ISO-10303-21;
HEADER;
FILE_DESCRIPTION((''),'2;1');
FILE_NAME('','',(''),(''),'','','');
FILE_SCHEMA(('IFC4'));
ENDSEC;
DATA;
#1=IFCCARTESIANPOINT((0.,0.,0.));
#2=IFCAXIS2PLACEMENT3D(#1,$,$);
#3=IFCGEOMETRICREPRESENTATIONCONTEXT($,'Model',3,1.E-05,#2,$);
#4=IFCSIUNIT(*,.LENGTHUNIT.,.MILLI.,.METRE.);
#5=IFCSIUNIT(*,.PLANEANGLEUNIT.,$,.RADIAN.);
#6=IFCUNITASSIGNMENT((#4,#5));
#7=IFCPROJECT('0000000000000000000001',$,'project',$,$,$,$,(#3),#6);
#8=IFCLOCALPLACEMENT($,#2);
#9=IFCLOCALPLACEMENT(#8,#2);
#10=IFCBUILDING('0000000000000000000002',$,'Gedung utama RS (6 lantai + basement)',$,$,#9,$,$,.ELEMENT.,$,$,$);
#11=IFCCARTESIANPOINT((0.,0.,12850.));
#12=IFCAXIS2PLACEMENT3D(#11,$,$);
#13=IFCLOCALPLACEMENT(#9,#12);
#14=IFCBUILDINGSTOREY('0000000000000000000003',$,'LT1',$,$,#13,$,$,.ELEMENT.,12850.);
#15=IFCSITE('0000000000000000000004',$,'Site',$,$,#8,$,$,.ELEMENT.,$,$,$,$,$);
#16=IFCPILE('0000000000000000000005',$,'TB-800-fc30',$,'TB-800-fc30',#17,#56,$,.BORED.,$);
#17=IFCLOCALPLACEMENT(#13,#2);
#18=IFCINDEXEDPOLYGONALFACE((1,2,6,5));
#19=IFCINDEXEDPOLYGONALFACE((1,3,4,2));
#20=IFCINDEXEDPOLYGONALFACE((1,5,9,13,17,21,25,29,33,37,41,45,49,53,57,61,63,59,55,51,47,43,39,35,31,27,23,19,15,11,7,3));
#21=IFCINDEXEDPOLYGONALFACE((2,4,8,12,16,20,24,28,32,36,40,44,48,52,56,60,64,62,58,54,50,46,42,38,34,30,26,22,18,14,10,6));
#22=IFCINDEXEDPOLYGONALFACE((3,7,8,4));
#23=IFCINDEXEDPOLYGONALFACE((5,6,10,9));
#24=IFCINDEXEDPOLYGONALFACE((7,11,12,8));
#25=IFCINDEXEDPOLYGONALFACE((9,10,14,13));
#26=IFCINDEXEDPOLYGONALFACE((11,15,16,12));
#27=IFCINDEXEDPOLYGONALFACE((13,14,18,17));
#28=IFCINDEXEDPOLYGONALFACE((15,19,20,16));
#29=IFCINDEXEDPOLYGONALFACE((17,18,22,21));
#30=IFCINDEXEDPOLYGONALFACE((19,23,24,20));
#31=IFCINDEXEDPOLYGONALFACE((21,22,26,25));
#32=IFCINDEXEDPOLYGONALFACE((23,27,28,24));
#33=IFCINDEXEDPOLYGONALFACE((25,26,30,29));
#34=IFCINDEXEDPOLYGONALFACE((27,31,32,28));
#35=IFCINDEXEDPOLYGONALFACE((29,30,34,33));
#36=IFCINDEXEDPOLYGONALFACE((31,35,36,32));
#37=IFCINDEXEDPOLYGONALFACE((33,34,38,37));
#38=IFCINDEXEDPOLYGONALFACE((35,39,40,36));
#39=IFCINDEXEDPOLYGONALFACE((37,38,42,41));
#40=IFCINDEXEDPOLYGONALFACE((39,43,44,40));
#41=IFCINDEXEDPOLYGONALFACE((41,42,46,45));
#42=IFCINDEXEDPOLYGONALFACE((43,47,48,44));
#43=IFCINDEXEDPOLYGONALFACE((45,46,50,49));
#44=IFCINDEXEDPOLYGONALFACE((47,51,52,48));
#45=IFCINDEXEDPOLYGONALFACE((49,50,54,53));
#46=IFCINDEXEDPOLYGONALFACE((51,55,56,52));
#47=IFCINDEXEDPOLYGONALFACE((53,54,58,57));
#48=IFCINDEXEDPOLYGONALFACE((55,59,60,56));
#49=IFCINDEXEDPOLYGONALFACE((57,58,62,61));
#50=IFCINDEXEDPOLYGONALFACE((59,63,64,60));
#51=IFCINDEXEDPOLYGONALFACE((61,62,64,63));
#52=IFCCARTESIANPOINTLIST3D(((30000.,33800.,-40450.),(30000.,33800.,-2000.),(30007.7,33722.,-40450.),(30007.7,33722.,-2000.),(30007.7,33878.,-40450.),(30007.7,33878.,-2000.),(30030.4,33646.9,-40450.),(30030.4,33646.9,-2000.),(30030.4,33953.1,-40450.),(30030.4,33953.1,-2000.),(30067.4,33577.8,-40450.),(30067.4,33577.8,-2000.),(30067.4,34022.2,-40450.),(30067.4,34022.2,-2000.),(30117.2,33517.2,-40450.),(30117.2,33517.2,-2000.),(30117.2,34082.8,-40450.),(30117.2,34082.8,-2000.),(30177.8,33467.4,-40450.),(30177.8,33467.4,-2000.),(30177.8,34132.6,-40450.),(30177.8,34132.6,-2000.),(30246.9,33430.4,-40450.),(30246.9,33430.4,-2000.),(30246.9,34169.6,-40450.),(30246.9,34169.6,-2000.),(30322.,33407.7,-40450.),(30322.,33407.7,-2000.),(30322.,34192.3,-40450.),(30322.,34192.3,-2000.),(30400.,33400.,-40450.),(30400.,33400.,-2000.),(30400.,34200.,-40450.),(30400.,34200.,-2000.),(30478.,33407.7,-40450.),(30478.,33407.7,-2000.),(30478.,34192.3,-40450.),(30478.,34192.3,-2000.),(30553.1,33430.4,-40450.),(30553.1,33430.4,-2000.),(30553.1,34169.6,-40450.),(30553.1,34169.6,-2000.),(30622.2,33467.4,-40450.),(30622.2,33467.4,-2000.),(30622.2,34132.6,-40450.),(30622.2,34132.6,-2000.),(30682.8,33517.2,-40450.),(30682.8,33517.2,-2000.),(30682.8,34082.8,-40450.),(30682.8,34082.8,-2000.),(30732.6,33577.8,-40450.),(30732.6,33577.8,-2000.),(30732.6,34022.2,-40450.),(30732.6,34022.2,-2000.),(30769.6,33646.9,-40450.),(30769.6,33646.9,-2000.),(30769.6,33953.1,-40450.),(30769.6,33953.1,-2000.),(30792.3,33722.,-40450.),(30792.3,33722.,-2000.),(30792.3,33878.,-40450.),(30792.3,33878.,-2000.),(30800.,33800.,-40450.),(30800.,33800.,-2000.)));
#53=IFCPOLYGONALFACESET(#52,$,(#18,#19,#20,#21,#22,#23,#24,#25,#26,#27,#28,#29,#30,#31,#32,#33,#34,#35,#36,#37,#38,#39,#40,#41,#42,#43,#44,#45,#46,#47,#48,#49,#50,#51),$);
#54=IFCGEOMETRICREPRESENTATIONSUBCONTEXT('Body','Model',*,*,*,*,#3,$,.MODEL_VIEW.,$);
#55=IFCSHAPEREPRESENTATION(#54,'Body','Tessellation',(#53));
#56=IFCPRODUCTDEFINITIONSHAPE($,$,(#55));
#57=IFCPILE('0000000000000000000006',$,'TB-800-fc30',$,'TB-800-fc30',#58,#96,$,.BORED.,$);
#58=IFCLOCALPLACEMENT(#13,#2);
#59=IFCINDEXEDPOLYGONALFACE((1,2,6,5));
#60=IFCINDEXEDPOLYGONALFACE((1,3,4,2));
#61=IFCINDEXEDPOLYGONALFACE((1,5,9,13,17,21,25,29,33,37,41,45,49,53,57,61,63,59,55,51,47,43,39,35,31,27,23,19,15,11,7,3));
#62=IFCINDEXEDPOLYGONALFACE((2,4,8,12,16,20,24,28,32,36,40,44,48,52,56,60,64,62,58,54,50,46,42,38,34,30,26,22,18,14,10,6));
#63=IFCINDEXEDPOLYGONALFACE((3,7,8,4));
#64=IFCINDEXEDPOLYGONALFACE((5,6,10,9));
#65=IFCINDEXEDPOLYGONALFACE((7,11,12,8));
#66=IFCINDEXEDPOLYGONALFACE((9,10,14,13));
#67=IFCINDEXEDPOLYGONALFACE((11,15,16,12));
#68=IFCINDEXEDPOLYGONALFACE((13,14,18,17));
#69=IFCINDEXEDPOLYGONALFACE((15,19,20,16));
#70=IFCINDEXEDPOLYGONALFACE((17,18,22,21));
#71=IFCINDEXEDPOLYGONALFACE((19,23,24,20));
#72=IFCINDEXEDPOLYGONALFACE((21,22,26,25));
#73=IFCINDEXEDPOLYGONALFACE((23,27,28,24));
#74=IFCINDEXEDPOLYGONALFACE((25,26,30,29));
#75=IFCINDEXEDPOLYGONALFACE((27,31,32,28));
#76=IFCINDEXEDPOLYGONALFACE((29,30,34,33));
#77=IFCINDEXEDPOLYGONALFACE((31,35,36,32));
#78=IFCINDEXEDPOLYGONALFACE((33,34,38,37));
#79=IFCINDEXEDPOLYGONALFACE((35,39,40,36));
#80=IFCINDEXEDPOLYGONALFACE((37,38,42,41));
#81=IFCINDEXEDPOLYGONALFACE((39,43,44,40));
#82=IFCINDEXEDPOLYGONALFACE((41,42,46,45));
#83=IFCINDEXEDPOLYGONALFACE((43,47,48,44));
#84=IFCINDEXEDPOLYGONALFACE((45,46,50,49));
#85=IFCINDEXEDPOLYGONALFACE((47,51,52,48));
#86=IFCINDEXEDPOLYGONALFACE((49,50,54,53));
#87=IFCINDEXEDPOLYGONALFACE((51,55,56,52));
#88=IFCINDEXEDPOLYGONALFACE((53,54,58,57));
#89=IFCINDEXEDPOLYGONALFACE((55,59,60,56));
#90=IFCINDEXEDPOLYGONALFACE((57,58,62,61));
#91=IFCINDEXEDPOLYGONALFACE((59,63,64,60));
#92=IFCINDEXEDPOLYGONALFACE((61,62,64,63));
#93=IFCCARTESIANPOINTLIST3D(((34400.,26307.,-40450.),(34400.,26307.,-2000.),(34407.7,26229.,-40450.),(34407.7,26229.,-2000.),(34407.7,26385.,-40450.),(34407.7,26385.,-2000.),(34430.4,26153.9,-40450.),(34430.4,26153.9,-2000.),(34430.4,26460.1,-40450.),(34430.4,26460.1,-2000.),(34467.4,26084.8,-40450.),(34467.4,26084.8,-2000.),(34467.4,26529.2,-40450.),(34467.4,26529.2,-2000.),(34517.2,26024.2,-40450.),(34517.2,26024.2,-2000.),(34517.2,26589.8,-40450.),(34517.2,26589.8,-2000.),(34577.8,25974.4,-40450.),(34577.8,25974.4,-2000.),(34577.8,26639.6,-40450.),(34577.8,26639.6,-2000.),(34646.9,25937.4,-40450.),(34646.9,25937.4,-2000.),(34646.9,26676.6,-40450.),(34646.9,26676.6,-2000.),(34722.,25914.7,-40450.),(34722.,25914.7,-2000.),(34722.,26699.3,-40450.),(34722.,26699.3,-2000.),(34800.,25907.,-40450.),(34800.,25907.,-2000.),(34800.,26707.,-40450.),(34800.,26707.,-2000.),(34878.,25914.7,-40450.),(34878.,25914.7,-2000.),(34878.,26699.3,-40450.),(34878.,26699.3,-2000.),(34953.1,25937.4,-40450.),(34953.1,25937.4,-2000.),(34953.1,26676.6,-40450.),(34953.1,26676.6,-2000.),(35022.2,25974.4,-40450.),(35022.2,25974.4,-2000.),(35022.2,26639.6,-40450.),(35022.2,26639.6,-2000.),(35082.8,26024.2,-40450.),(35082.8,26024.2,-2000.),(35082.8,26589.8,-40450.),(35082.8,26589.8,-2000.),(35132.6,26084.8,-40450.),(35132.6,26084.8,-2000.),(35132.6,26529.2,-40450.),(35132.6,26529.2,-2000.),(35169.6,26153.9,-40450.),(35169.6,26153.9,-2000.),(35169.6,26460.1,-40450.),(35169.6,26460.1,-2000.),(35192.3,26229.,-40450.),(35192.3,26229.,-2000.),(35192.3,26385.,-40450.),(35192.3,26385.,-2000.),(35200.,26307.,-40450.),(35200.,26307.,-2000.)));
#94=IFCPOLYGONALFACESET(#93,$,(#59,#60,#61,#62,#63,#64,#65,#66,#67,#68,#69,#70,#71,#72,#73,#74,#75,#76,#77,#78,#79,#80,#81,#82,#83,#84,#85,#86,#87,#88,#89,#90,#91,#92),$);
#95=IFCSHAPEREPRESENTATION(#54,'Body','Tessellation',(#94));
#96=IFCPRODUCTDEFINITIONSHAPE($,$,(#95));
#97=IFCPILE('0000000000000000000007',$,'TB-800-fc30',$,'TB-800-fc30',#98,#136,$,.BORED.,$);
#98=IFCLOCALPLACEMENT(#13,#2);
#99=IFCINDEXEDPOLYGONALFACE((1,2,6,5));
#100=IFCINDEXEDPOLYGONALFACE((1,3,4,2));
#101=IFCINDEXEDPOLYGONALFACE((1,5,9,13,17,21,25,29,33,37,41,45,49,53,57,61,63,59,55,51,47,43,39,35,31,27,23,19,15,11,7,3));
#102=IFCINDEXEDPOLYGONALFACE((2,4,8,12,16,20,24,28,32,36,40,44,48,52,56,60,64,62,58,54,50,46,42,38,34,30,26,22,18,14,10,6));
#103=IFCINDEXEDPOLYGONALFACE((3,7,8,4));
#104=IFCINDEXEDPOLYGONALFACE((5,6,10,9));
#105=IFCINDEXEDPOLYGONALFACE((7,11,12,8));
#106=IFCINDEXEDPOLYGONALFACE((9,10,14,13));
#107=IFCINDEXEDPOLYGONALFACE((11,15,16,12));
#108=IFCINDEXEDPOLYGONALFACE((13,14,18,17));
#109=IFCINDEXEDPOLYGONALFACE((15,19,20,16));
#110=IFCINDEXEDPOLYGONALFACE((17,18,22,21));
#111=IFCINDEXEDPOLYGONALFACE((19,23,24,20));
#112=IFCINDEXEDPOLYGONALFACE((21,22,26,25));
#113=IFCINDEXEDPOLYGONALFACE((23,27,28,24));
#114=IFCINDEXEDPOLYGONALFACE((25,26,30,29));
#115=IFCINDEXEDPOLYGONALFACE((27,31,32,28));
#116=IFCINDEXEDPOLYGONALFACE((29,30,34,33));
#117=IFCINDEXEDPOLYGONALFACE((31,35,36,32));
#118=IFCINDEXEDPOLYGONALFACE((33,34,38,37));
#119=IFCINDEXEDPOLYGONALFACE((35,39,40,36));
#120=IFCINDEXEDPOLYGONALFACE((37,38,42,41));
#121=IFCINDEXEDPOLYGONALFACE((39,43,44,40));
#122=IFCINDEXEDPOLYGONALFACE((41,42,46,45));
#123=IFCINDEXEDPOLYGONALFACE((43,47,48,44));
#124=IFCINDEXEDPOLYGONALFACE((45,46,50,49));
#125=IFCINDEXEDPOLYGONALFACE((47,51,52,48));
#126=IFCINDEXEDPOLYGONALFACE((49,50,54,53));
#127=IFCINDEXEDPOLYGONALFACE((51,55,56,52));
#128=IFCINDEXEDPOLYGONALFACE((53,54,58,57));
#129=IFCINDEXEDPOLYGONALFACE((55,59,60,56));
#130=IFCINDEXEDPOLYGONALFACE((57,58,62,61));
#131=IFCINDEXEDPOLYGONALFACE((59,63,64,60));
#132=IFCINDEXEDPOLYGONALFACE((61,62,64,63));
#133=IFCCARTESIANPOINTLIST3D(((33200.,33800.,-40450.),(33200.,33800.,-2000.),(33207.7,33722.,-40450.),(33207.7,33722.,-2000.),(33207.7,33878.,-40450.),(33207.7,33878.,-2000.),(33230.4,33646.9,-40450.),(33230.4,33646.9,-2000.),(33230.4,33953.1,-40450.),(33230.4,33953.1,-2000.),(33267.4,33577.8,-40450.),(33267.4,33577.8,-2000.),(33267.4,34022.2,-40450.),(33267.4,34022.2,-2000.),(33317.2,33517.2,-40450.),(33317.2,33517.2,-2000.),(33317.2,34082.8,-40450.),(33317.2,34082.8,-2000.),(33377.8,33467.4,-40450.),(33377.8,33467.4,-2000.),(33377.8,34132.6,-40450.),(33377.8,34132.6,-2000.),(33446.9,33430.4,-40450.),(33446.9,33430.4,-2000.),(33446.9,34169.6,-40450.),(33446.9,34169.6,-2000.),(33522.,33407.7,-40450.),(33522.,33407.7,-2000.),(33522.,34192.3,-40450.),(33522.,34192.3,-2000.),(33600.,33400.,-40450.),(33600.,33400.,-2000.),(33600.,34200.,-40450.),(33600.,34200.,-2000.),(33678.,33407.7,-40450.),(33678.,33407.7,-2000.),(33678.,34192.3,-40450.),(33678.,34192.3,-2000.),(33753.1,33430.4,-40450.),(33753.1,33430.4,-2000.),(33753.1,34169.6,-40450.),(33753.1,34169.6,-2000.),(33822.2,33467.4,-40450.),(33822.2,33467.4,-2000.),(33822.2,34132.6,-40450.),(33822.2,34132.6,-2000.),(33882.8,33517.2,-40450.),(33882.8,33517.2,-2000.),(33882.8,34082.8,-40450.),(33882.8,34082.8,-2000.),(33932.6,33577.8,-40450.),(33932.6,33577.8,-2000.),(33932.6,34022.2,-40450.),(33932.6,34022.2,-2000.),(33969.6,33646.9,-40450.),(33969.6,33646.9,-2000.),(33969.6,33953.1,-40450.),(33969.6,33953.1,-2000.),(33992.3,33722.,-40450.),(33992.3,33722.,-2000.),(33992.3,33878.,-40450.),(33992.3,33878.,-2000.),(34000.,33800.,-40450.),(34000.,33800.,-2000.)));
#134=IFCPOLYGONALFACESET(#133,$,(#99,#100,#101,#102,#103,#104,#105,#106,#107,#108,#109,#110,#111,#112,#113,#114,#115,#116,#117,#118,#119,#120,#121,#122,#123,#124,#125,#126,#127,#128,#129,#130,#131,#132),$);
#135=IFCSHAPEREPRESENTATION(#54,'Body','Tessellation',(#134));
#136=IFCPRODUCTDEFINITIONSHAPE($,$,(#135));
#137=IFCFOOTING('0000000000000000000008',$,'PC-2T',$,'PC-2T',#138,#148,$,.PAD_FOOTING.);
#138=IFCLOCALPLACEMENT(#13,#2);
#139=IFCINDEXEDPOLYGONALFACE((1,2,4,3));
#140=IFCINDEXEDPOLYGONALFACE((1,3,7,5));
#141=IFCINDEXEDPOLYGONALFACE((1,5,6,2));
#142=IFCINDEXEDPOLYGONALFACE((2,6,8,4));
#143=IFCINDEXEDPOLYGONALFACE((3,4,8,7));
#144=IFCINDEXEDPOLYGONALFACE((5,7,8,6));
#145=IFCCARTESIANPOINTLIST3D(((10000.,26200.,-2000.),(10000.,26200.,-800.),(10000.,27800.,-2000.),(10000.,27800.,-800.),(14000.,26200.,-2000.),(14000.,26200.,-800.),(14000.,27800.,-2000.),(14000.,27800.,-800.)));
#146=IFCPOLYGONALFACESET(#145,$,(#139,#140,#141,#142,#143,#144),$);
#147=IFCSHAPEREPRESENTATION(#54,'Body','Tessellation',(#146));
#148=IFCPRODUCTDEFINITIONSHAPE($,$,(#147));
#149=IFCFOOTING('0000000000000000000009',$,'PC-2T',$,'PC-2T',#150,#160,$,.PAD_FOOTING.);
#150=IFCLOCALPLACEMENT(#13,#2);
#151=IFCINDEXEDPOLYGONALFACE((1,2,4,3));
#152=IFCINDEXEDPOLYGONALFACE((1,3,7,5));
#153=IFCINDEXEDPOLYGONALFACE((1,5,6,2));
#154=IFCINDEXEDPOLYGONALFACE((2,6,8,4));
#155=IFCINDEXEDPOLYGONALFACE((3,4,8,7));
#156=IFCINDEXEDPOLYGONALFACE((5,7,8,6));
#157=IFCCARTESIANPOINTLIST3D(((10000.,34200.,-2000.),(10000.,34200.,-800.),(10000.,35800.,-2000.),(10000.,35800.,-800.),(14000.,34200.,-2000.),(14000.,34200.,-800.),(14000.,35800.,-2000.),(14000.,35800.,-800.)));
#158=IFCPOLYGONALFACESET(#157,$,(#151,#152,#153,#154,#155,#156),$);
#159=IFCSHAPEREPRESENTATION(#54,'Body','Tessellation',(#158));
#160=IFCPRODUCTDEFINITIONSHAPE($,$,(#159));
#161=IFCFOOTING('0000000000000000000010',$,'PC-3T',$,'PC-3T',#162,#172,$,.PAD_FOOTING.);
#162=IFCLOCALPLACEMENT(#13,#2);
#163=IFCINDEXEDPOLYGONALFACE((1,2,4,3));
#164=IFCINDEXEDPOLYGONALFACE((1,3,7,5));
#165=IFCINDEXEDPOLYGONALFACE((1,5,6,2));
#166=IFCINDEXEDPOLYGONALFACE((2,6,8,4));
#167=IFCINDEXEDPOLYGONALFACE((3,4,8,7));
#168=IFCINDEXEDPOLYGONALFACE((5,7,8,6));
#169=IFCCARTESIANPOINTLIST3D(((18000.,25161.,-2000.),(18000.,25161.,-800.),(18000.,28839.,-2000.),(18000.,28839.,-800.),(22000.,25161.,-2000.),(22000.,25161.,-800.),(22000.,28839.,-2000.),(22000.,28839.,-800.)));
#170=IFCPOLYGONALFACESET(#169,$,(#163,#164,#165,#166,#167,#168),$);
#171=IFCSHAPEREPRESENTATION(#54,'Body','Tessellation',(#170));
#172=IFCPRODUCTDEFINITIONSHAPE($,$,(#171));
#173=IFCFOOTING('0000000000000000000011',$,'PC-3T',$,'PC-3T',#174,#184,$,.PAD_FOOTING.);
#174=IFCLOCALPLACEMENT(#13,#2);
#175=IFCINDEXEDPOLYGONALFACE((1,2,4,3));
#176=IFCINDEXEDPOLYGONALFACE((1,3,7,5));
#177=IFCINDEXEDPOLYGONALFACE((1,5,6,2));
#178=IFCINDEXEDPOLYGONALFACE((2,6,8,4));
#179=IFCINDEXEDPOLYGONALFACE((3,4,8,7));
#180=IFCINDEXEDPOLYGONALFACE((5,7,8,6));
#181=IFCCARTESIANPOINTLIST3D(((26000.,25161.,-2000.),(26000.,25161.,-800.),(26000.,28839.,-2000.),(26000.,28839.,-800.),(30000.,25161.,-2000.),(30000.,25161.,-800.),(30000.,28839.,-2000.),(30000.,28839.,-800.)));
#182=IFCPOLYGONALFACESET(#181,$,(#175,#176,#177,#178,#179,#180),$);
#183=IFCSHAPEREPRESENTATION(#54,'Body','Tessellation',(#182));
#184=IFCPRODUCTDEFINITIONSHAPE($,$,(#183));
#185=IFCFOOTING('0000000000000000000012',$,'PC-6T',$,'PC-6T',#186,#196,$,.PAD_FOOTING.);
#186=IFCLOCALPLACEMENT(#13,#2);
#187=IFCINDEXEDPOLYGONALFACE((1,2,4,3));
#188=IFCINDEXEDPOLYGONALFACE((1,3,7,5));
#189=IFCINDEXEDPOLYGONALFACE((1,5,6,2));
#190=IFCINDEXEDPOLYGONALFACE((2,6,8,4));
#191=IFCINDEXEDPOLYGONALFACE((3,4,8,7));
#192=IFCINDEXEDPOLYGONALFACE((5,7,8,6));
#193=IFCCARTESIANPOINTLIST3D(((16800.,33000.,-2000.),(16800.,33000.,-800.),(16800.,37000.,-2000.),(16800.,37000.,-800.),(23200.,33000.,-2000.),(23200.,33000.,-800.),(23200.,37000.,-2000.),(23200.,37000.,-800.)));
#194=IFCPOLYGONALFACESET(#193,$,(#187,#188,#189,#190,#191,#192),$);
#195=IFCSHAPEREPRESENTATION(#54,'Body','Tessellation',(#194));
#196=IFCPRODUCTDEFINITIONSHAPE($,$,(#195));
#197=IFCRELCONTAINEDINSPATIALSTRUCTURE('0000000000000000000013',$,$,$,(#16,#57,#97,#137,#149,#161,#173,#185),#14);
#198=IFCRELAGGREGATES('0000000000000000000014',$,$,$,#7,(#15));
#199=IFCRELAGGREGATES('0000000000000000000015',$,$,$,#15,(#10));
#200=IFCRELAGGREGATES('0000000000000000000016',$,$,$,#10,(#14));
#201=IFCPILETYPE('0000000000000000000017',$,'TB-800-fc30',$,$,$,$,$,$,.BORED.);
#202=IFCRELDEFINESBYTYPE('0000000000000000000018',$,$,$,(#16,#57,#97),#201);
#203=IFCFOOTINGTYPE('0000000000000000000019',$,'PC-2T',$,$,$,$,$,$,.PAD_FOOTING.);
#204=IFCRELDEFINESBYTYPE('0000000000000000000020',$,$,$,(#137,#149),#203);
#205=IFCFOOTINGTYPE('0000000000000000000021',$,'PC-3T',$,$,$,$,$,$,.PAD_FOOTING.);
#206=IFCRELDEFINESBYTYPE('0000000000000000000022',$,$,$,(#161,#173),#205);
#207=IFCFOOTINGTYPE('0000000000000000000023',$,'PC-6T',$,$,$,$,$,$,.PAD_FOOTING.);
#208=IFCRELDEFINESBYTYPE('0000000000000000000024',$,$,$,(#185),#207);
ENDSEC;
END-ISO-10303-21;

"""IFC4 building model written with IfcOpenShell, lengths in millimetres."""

from ifc_helpers import new_model, si_unit, frame, origin, origin_2d, place, context, subcontext, project, spatial, rectangle, circle, extrude, material_profile, profile_set, profile_usage, type_object, element, save


model = new_model("IFC4")

# Units and contexts
model_context = context("Model", 3, precision=1e-05, world=origin())
body_context = subcontext(model_context, "Body", "Model", "MODEL_VIEW")
ifc_project = project(units=[si_unit("LENGTHUNIT", "METRE", prefix="MILLI"), si_unit("PLANEANGLEUNIT", "RADIAN")], contexts=[model_context])

# Site, building, storey
site_placement = place(None, origin())
site = spatial("IfcSite", under=ifc_project, at=site_placement, Name="Site", CompositionType="ELEMENT")
building_placement = place(site_placement, origin())
building = spatial("IfcBuilding", under=site, at=building_placement, Name="Gedung utama RS (6 lantai + basement)", CompositionType="ELEMENT")
storey_placement = place(building_placement, frame((0.0, 0.0, 12850.0)))
storey = spatial("IfcBuildingStorey", under=building, at=storey_placement, Name="LT1", CompositionType="ELEMENT", Elevation=12850.0)

# Piles
ifc_material_profile_1 = material_profile(None, circle(Radius=400.0, at=origin_2d()), Name="TB-800-fc30")
ifc_profile_set_1 = profile_set([ifc_material_profile_1], Name="TB-800-fc30")
ifc_profile_usage_1 = profile_usage(ifc_profile_set_1, cardinal=5)
pile_type = type_object("IfcPileType", Name="TB-800-fc30", PredefinedType="BORED", material=ifc_profile_set_1)
for number, where, z_axis, x_axis, name in (
    (1, (30400.0, 33800.0, -40450.0), (0.0, 0.0, 1.0), (1.0, 0.0, 0.0), "TB-800-fc30"),
    (2, (34800.0, 26307.0, -40450.0), (0.0, 0.0, 1.0), (1.0, 0.0, 0.0), "TB-800-fc30"),
    (3, (33600.0, 33800.0, -40450.0), (0.0, 0.0, 1.0), (1.0, 0.0, 0.0), "TB-800-fc30"),
):
    element("IfcPile", number, at=place(storey_placement, frame(where, z_axis=z_axis, x_axis=x_axis)), inside=storey, type_object=pile_type, material=ifc_profile_usage_1, Name=name, ObjectType="TB-800-fc30", PredefinedType="BORED", context=body_context, shape_type="SweptSolid", body=[
        extrude(circle(Radius=400.0, at=origin_2d()), origin(), (0.0, 0.0, 1.0), 38450.0),
    ])

# Footings
ifc_material_profile_2 = material_profile(None, rectangle(XDim=4000.0, YDim=1600.0, at=origin_2d()), Name="PC-2T")
ifc_profile_set_2 = profile_set([ifc_material_profile_2], Name="PC-2T")
ifc_profile_usage_2 = profile_usage(ifc_profile_set_2, cardinal=5)
footing_type_1 = type_object("IfcFootingType", Name="PC-2T", PredefinedType="PAD_FOOTING", material=ifc_profile_set_2)
for number, where, z_axis, x_axis, name in (
    (4, (12000.0, 27000.0, -2000.0), (0.0, 0.0, 1.0), (1.0, 0.0, 0.0), "PC-2T"),
    (5, (12000.0, 35000.0, -2000.0), (0.0, 0.0, 1.0), (1.0, 0.0, 0.0), "PC-2T"),
):
    element("IfcFooting", number, at=place(storey_placement, frame(where, z_axis=z_axis, x_axis=x_axis)), inside=storey, type_object=footing_type_1, material=ifc_profile_usage_2, Name=name, ObjectType="PC-2T", PredefinedType="PAD_FOOTING", context=body_context, shape_type="SweptSolid", body=[
        extrude(rectangle(XDim=4000.0, YDim=1600.0, at=origin_2d()), origin(), (0.0, 0.0, 1.0), 1200.0),
    ])
ifc_material_profile_3 = material_profile(None, rectangle(XDim=4000.0, YDim=3678.0, at=origin_2d()), Name="PC-3T")
ifc_profile_set_3 = profile_set([ifc_material_profile_3], Name="PC-3T")
ifc_profile_usage_3 = profile_usage(ifc_profile_set_3, cardinal=5)
footing_type_2 = type_object("IfcFootingType", Name="PC-3T", PredefinedType="PAD_FOOTING", material=ifc_profile_set_3)
for number, where, z_axis, x_axis, name in (
    (6, (20000.0, 27000.0, -2000.0), (0.0, 0.0, 1.0), (1.0, 0.0, 0.0), "PC-3T"),
    (7, (28000.0, 27000.0, -2000.0), (0.0, 0.0, 1.0), (1.0, 0.0, 0.0), "PC-3T"),
):
    element("IfcFooting", number, at=place(storey_placement, frame(where, z_axis=z_axis, x_axis=x_axis)), inside=storey, type_object=footing_type_2, material=ifc_profile_usage_3, Name=name, ObjectType="PC-3T", PredefinedType="PAD_FOOTING", context=body_context, shape_type="SweptSolid", body=[
        extrude(rectangle(XDim=4000.0, YDim=3678.0, at=origin_2d()), origin(), (0.0, 0.0, 1.0), 1200.0),
    ])
ifc_material_profile_4 = material_profile(None, rectangle(XDim=6400.0, YDim=4000.0, at=origin_2d()), Name="PC-6T")
ifc_profile_set_4 = profile_set([ifc_material_profile_4], Name="PC-6T")
ifc_profile_usage_4 = profile_usage(ifc_profile_set_4, cardinal=5)
footing_type_3 = type_object("IfcFootingType", Name="PC-6T", PredefinedType="PAD_FOOTING", material=ifc_profile_set_4)
for number, where, z_axis, x_axis, name in (
    (8, (20000.0, 35000.0, -2000.0), (0.0, 0.0, 1.0), (1.0, 0.0, 0.0), "PC-6T"),
):
    element("IfcFooting", number, at=place(storey_placement, frame(where, z_axis=z_axis, x_axis=x_axis)), inside=storey, type_object=footing_type_3, material=ifc_profile_usage_4, Name=name, ObjectType="PC-6T", PredefinedType="PAD_FOOTING", context=body_context, shape_type="SweptSolid", body=[
        extrude(rectangle(XDim=6400.0, YDim=4000.0, at=origin_2d()), origin(), (0.0, 0.0, 1.0), 1200.0),
    ])

save(model, "model.ifc")
